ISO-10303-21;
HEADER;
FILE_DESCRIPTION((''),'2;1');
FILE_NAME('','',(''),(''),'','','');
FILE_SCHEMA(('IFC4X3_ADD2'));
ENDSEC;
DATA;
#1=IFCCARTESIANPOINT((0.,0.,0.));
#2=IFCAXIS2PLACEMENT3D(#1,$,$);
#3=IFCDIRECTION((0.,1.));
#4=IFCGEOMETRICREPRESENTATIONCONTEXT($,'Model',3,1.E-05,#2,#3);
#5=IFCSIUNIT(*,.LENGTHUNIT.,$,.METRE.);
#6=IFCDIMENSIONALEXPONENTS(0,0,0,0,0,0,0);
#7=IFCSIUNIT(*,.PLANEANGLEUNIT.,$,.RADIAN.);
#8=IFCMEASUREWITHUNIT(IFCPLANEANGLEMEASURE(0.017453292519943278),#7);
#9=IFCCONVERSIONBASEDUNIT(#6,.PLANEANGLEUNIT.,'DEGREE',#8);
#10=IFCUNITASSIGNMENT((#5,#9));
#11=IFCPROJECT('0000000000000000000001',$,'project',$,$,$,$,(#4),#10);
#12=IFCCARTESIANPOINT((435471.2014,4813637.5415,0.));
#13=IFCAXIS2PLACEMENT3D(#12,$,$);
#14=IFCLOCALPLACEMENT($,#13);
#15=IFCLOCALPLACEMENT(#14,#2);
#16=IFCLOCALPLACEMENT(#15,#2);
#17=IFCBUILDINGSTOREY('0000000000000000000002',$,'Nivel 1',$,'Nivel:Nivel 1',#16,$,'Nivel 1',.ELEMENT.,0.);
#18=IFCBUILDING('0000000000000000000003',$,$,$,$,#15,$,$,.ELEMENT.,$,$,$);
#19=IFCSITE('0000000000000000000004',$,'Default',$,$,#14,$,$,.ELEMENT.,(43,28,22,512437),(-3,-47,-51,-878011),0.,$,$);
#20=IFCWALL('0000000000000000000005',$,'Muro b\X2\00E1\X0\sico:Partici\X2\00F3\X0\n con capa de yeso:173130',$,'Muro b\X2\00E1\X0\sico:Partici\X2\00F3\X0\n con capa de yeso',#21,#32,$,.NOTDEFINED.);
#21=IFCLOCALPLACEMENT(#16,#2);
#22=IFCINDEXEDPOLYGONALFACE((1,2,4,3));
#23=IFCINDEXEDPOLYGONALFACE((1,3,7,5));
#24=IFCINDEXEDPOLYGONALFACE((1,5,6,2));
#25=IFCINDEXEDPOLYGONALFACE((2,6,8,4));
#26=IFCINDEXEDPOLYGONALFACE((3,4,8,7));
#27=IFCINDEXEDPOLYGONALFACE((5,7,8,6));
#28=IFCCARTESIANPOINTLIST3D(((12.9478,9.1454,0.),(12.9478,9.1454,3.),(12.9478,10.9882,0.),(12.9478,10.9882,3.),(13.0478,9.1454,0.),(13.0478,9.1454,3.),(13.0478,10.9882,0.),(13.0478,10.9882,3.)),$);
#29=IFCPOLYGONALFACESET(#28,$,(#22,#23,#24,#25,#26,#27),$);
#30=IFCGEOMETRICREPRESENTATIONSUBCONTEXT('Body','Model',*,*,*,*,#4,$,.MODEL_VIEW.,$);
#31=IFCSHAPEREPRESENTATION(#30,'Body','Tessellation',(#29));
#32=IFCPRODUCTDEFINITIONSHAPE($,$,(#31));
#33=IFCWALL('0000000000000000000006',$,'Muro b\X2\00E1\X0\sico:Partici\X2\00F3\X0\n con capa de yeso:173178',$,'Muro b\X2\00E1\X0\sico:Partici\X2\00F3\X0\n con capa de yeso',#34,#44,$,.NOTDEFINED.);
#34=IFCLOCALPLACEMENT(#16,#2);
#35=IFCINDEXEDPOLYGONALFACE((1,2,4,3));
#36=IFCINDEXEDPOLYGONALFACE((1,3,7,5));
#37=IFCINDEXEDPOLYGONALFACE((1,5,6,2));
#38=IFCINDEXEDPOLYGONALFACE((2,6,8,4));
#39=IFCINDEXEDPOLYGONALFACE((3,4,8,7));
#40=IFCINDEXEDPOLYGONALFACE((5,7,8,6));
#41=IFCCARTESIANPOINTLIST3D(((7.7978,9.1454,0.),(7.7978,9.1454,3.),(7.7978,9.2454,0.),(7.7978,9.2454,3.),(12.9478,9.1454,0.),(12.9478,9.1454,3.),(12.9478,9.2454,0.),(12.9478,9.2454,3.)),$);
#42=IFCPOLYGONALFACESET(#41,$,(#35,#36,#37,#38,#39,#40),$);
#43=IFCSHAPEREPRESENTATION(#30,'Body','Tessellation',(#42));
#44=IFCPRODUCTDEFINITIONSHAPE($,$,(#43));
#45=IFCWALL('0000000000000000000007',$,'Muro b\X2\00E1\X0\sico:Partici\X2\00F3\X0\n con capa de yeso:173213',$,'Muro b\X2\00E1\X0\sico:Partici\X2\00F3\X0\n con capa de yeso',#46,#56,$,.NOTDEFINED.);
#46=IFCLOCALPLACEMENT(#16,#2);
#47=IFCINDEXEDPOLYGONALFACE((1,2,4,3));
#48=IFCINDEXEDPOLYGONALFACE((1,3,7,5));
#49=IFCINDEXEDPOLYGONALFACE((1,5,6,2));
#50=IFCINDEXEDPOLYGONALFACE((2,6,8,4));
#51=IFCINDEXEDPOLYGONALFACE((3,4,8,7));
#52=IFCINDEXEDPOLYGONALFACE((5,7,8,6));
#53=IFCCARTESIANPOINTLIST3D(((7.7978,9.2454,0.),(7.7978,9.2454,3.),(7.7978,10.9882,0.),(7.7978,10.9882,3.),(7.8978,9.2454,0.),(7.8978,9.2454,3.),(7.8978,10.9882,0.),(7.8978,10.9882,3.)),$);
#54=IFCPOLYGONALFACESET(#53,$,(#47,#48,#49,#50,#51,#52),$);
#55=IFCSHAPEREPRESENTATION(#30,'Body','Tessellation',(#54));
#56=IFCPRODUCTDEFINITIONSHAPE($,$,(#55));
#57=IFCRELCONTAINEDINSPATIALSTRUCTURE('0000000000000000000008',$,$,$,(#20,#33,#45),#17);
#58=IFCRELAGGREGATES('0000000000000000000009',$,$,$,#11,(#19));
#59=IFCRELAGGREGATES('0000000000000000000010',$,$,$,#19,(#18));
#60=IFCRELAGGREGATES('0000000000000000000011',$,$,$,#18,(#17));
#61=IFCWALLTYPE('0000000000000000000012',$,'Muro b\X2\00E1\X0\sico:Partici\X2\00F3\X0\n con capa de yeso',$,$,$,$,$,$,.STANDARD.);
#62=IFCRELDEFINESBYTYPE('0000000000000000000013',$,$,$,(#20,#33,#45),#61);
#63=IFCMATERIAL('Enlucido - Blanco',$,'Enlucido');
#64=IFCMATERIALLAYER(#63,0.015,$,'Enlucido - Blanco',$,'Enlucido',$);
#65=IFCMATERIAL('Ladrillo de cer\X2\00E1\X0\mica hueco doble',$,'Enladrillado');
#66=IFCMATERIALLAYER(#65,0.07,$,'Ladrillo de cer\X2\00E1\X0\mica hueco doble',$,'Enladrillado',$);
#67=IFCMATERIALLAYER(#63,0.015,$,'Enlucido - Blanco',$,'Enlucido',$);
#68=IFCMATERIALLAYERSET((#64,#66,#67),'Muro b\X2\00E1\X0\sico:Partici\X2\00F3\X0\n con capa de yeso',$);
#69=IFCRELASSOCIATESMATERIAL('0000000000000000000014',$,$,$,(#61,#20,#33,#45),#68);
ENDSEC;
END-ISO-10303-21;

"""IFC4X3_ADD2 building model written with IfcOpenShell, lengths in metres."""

from ifc_helpers import new_model, entity, si_unit, converted_unit, direction, frame, frame_2d, origin, place, context, subcontext, project, spatial, rectangle, extrude, material, layer, layer_set, type_object, element, save


model = new_model("IFC4X3_ADD2")

# Units and contexts
model_context = context("Model", 3, precision=1e-05, world=origin(), true_north=direction((0.0, 1.0)))
body_context = subcontext(model_context, "Body", "Model", "MODEL_VIEW")
ifc_project = project(units=[si_unit("LENGTHUNIT", "METRE"), converted_unit("PLANEANGLEUNIT", "DEGREE", entity("IfcPlaneAngleMeasure", 0.017453292519943278), si_unit("PLANEANGLEUNIT", "RADIAN"), dimensions=[0, 0, 0, 0, 0, 0, 0])], contexts=[model_context])

# Site, building, storey
site_placement = place(None, frame((435471.2014, 4813637.5415, 0.0)))
site = spatial("IfcSite", under=ifc_project, at=site_placement, Name="Default", CompositionType="ELEMENT", RefLatitude=(43, 28, 22, 512437), RefLongitude=(-3, -47, -51, -878011), RefElevation=0.0)
building_placement = place(site_placement, origin())
building = spatial("IfcBuilding", under=site, at=building_placement, CompositionType="ELEMENT")
storey_placement = place(building_placement, origin())
storey = spatial("IfcBuildingStorey", under=building, at=storey_placement, Name="Nivel 1", ObjectType="Nivel:Nivel 1", LongName="Nivel 1", CompositionType="ELEMENT", Elevation=0.0)

# Shared definitions
ifc_material_1 = material(Name="Enlucido - Blanco", Category="Enlucido")

# Shared definitions
ifc_layer_1 = layer(ifc_material_1, 0.015, Name="Enlucido - Blanco", Category="Enlucido")
ifc_material_2 = material(Name="Ladrillo de cerámica hueco doble", Category="Enladrillado")
ifc_layer_2 = layer(ifc_material_2, 0.07, Name="Ladrillo de cerámica hueco doble", Category="Enladrillado")
ifc_layer_3 = layer(ifc_material_1, 0.015, Name="Enlucido - Blanco", Category="Enlucido")
ifc_layer_set_1 = layer_set([ifc_layer_1, ifc_layer_2, ifc_layer_3], Name="Muro básico:Partición con capa de yeso")
wall_type_1 = type_object("IfcWallType", Name="Muro básico:Partición con capa de yeso", PredefinedType="STANDARD", material=ifc_layer_set_1)

# Walls
wall_1_placement = place(storey_placement, frame((12.9978, 10.9882, 0.0), z_axis=(0.0, 0.0, 1.0), x_axis=(0.0, -1.0, 0.0)))
element("IfcWall", 1, at=wall_1_placement, inside=storey, type_object=wall_type_1, material=ifc_layer_set_1, Name="Muro básico:Partición con capa de yeso:173130", ObjectType="Muro básico:Partición con capa de yeso", PredefinedType="NOTDEFINED", context=body_context, shape_type="SweptSolid", body=[
    extrude(rectangle(XDim=1.8428, YDim=0.1, at=frame_2d((0.9214, 0.0), x_axis=(-1.0, 0.0))), origin(), (0.0, 0.0, 1.0), 3.0),
])
wall_2_placement = place(storey_placement, frame((12.9478, 9.1954, 0.0), z_axis=(0.0, 0.0, 1.0), x_axis=(-1.0, 0.0, 0.0)))
element("IfcWall", 2, at=wall_2_placement, inside=storey, type_object=wall_type_1, material=ifc_layer_set_1, Name="Muro básico:Partición con capa de yeso:173178", ObjectType="Muro básico:Partición con capa de yeso", PredefinedType="NOTDEFINED", context=body_context, shape_type="SweptSolid", body=[
    extrude(rectangle(XDim=5.15, YDim=0.1, at=frame_2d((2.575, 0.0), x_axis=(-1.0, 0.0))), origin(), (0.0, 0.0, 1.0), 3.0),
])
wall_3_placement = place(storey_placement, frame((7.8478, 9.2454, 0.0), z_axis=(0.0, 0.0, 1.0), x_axis=(0.0, 1.0, 0.0)))
element("IfcWall", 3, at=wall_3_placement, inside=storey, type_object=wall_type_1, material=ifc_layer_set_1, Name="Muro básico:Partición con capa de yeso:173213", ObjectType="Muro básico:Partición con capa de yeso", PredefinedType="NOTDEFINED", context=body_context, shape_type="SweptSolid", body=[
    extrude(rectangle(XDim=1.7428, YDim=0.1, at=frame_2d((0.8714, 0.0), x_axis=(-1.0, 0.0))), origin(), (0.0, 0.0, 1.0), 3.0),
])

save(model, "model.ifc")
